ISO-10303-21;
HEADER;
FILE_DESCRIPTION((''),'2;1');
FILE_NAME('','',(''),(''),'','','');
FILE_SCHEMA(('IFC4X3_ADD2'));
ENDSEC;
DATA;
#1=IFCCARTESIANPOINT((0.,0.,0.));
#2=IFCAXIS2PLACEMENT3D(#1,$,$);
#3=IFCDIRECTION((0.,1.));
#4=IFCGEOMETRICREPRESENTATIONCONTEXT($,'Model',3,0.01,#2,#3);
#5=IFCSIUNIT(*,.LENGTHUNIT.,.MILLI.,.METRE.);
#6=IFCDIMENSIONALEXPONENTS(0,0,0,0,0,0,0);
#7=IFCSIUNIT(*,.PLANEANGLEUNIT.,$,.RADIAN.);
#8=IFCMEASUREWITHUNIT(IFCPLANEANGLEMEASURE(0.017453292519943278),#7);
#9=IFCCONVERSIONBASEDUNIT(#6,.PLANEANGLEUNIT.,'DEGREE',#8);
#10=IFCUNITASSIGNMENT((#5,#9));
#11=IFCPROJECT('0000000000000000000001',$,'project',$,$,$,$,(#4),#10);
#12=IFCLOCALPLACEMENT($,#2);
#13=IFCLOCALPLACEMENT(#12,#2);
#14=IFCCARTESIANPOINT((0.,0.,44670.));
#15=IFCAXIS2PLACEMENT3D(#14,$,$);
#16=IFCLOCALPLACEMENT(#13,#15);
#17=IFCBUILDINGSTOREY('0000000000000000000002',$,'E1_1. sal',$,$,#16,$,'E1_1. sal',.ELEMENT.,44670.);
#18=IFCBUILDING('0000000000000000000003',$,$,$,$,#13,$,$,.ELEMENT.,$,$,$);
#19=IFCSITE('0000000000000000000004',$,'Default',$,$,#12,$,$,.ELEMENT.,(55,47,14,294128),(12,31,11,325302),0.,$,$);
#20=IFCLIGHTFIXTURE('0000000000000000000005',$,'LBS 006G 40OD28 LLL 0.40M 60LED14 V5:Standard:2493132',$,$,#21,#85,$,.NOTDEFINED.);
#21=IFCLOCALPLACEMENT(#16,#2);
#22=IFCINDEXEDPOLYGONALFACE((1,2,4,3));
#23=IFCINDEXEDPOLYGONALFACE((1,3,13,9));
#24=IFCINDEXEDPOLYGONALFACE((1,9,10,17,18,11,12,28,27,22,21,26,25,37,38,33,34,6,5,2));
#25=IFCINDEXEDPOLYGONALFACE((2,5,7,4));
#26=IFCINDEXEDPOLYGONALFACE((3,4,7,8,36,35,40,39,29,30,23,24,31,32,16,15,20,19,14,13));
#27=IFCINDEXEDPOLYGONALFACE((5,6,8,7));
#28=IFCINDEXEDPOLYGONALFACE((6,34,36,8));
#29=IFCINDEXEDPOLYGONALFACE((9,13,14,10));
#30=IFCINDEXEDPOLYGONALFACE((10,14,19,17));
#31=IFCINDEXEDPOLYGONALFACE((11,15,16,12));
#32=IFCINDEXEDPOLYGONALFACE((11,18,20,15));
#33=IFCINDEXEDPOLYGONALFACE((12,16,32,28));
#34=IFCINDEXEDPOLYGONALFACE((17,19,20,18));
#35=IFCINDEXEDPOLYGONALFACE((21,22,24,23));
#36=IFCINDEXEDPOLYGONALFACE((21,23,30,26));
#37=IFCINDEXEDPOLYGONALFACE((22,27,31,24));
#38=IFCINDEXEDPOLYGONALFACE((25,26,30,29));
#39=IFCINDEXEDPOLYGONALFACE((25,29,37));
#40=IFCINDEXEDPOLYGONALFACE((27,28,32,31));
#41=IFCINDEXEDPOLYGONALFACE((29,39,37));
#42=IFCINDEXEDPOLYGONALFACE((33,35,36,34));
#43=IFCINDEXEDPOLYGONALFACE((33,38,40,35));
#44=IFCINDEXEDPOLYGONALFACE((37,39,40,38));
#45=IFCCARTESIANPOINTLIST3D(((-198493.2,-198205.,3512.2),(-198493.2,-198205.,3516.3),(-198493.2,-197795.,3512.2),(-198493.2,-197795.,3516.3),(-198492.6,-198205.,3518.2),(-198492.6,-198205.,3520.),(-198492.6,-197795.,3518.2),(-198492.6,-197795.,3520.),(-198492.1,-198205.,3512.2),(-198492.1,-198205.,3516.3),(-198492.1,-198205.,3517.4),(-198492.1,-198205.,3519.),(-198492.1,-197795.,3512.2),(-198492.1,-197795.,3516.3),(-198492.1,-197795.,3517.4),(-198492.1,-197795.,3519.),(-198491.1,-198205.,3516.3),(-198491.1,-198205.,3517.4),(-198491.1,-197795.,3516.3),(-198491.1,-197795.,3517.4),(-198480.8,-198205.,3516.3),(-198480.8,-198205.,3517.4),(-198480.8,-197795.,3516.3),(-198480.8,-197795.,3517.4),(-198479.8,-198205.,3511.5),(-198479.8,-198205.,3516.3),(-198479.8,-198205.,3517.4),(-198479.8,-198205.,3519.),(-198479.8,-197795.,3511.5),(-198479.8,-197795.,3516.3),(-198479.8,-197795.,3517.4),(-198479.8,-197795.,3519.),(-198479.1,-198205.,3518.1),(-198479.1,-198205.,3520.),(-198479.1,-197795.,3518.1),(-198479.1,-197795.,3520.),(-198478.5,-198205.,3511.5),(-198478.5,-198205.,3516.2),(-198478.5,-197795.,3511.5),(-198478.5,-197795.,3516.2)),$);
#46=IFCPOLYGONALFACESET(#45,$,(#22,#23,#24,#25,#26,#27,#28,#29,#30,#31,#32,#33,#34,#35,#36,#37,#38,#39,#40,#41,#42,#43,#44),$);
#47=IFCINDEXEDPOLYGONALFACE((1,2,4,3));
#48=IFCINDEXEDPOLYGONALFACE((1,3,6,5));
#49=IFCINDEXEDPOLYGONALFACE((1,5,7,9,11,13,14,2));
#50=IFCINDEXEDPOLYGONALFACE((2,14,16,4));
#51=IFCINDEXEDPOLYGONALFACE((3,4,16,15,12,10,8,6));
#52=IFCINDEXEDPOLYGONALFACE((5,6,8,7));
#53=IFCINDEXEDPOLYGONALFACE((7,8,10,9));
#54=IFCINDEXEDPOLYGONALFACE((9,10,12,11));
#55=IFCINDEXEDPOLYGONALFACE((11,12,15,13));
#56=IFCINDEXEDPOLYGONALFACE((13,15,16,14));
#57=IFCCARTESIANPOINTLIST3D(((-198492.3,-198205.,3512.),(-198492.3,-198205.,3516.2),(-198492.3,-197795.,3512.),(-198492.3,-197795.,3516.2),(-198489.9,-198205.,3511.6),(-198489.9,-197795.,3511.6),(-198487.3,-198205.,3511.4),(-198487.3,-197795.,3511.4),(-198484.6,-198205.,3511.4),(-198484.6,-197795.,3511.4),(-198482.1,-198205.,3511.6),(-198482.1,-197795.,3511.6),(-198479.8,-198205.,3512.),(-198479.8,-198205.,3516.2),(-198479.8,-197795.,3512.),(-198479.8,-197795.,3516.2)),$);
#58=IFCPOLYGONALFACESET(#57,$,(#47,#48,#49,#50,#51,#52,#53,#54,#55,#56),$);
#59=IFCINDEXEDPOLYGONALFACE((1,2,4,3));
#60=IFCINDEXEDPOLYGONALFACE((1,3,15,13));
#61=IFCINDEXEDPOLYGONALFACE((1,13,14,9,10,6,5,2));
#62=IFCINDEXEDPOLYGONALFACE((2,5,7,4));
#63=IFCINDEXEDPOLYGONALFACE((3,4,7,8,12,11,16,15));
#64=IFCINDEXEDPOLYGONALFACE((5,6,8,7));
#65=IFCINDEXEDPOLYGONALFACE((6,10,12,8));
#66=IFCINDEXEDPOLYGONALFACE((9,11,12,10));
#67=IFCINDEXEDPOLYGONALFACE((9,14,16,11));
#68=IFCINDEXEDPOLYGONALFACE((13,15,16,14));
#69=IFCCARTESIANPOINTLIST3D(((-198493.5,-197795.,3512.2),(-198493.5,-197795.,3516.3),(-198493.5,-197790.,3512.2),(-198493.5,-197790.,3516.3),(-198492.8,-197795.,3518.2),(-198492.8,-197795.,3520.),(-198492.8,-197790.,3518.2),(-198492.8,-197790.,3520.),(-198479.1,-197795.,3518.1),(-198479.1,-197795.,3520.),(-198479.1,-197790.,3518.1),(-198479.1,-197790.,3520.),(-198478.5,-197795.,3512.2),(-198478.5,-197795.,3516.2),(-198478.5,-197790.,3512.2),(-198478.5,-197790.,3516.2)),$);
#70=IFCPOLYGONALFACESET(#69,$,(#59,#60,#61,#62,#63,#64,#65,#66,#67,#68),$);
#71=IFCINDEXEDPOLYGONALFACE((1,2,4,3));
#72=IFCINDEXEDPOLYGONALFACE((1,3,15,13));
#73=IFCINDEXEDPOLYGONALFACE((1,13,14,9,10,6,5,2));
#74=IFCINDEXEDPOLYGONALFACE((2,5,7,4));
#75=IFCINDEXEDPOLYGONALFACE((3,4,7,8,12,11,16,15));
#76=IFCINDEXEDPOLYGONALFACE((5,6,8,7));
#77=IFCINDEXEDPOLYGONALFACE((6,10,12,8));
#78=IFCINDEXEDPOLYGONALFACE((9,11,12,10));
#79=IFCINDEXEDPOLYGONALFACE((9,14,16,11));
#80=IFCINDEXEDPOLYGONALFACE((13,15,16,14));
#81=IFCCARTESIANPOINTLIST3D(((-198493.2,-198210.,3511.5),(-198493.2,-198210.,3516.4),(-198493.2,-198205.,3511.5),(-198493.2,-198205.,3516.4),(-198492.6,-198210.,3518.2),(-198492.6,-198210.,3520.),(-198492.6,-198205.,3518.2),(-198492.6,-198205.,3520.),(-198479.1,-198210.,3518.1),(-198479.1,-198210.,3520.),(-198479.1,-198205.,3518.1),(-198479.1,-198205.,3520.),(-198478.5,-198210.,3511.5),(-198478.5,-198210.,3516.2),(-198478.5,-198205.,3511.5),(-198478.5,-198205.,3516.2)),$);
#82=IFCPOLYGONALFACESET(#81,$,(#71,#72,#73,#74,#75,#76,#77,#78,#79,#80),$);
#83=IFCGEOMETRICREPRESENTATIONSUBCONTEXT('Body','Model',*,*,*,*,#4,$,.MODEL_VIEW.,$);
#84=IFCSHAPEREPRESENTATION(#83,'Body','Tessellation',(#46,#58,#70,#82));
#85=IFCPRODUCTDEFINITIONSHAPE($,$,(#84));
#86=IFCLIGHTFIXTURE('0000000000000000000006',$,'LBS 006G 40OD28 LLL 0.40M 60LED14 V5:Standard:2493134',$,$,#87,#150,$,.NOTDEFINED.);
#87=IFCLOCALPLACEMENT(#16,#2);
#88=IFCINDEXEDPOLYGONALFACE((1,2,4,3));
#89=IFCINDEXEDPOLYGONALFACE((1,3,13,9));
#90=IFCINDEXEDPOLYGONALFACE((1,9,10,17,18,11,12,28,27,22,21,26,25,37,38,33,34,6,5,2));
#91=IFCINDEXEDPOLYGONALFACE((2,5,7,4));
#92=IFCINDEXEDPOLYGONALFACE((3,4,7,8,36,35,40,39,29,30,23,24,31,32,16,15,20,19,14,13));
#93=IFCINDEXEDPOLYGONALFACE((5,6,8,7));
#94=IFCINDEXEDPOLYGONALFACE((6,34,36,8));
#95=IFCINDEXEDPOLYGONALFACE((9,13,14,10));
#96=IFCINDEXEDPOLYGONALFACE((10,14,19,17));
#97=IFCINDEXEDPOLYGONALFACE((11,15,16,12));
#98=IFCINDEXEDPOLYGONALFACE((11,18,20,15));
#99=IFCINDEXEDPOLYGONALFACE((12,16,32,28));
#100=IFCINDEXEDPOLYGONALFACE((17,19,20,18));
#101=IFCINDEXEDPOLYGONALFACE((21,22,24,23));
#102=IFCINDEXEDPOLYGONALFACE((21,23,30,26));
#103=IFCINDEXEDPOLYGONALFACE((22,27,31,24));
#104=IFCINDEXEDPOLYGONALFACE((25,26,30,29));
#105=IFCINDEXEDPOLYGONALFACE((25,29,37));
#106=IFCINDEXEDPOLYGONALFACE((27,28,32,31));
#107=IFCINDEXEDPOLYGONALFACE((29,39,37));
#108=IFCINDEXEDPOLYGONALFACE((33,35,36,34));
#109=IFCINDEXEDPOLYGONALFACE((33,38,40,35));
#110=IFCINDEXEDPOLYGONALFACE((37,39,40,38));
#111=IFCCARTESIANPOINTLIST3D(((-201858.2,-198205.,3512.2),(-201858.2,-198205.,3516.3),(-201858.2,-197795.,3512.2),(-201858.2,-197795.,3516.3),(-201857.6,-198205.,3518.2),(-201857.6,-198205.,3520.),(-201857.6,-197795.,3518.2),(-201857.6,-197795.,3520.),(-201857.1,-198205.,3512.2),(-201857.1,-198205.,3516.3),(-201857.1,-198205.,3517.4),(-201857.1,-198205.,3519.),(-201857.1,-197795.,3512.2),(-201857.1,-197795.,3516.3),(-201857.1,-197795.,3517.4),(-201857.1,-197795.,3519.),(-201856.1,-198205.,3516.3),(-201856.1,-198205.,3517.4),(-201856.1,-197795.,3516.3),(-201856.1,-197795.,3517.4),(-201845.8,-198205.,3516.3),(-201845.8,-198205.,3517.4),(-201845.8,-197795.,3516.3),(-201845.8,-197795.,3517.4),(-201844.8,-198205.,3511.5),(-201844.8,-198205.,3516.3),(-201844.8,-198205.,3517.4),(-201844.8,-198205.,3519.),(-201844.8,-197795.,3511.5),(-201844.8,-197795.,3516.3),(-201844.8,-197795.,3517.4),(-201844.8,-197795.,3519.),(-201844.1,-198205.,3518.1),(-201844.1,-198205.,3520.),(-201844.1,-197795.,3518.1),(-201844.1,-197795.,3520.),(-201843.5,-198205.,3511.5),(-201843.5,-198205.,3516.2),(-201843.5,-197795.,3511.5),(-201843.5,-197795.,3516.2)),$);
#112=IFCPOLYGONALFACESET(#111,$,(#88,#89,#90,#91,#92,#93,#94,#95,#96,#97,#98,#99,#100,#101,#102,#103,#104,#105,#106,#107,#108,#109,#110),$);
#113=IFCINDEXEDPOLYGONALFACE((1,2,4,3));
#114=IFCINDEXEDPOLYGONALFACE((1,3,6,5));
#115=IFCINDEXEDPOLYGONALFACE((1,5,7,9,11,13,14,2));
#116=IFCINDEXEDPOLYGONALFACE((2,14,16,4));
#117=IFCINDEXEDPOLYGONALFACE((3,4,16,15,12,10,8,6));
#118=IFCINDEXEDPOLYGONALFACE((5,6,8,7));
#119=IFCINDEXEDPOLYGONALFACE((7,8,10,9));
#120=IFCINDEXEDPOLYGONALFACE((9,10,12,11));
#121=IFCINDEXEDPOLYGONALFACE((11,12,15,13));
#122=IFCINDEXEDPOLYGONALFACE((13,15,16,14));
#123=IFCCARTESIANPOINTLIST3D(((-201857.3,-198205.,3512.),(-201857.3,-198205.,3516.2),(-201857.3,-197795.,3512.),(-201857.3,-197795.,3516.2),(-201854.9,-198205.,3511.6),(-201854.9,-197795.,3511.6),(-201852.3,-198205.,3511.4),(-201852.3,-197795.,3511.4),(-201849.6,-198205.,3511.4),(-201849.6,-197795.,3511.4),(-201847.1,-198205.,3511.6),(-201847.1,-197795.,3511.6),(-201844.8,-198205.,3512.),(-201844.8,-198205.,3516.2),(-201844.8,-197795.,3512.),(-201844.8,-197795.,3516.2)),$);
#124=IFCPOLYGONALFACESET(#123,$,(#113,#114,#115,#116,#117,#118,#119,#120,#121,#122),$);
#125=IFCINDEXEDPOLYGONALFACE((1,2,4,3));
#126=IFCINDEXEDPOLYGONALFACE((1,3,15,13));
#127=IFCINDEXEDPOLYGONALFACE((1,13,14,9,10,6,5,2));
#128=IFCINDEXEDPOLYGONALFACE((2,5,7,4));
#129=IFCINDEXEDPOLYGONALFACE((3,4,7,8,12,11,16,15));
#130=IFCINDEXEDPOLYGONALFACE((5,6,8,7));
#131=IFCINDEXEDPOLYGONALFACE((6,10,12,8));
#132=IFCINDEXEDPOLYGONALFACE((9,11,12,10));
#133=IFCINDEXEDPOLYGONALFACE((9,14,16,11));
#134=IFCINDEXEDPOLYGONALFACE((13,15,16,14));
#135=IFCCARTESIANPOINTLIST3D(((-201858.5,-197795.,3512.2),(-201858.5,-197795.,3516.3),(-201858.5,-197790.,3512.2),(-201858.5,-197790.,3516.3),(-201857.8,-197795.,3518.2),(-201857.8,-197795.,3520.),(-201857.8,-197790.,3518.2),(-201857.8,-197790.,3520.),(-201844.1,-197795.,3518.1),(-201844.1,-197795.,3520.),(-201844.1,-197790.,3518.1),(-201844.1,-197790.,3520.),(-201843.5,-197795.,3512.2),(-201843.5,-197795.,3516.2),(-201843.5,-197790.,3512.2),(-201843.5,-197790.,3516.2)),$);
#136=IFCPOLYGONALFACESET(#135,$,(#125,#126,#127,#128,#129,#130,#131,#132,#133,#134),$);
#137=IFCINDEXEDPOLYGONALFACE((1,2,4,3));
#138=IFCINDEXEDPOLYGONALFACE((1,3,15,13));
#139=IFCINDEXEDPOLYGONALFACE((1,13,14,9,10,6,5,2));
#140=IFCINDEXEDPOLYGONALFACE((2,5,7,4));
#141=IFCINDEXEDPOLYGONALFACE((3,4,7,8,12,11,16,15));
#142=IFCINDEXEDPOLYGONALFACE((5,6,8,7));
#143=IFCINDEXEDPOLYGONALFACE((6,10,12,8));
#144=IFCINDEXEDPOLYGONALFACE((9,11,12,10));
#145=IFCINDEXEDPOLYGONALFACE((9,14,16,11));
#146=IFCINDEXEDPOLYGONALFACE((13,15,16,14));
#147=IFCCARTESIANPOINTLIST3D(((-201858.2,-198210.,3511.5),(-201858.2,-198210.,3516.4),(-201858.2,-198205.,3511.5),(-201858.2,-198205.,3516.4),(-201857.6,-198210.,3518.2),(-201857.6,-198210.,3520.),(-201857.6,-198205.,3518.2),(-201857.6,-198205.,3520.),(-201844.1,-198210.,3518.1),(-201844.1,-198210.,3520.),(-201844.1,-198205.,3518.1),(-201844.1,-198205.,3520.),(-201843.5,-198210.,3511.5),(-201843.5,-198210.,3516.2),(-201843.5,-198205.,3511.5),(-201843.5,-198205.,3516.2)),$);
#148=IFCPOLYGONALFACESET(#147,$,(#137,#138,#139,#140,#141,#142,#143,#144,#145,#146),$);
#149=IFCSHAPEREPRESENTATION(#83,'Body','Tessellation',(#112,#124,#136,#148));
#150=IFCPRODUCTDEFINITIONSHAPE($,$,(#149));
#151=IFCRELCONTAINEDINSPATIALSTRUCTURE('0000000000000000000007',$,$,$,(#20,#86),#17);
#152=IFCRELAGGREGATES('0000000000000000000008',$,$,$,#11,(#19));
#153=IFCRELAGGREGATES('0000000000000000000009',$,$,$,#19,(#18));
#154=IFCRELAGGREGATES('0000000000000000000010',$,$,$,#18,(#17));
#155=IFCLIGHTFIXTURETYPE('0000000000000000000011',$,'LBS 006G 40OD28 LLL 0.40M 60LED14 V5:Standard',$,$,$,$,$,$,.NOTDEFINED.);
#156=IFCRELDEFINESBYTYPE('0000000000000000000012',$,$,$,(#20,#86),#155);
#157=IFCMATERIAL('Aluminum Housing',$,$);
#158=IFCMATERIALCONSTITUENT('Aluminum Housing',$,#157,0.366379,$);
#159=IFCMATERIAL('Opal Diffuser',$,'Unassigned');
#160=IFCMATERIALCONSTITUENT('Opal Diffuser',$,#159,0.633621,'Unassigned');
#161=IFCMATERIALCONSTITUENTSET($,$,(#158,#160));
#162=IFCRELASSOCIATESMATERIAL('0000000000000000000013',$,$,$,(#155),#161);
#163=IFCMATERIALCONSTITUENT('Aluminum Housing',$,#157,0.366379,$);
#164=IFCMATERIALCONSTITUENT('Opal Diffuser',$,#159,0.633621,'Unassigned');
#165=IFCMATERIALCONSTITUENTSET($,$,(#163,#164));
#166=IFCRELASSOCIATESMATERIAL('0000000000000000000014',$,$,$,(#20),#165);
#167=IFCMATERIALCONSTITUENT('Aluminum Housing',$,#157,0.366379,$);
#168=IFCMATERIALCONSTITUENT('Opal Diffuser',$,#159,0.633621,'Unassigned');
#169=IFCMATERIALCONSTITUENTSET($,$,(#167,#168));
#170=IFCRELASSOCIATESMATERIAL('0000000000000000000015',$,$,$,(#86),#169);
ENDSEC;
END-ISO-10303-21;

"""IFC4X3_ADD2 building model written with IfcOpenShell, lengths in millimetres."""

from ifc_helpers import new_model, entity, si_unit, converted_unit, direction, frame, origin, place, context, subcontext, project, spatial, polyline, outline, extrude, source, transform, mapped, material, constituent, constituent_set, type_object, type_shapes, element, save


model = new_model("IFC4X3_ADD2")

# Units and contexts
model_context = context("Model", 3, precision=0.01, world=origin(), true_north=direction((0.0, 1.0)))
body_context = subcontext(model_context, "Body", "Model", "MODEL_VIEW")
ifc_project = project(units=[si_unit("LENGTHUNIT", "METRE", prefix="MILLI"), converted_unit("PLANEANGLEUNIT", "DEGREE", entity("IfcPlaneAngleMeasure", 0.017453292519943278), si_unit("PLANEANGLEUNIT", "RADIAN"), dimensions=[0, 0, 0, 0, 0, 0, 0])], contexts=[model_context])

# Site, building, storey
site_placement = place(None, origin())
site = spatial("IfcSite", under=ifc_project, at=site_placement, Name="Default", CompositionType="ELEMENT", RefLatitude=(55, 47, 14, 294128), RefLongitude=(12, 31, 11, 325302), RefElevation=0.0)
building_placement = place(site_placement, origin())
building = spatial("IfcBuilding", under=site, at=building_placement, CompositionType="ELEMENT")
storey_placement = place(building_placement, frame((0.0, 0.0, 44670.0)))
storey = spatial("IfcBuildingStorey", under=building, at=storey_placement, Name="E1_1. sal", LongName="E1_1. sal", CompositionType="ELEMENT", Elevation=44670.0)

# Light fixtures
ifc_material_1 = material(Name="Aluminum Housing")
ifc_constituent_1 = constituent(ifc_material_1, Name="Aluminum Housing", fraction=0.366379)
ifc_material_2 = material(Name="Opal Diffuser", Category="Unassigned")
ifc_constituent_2 = constituent(ifc_material_2, Name="Opal Diffuser", Category="Unassigned", fraction=0.633621)
ifc_constituent_set_1 = constituent_set(constituents=[ifc_constituent_1, ifc_constituent_2])
ifc_constituent_3 = constituent(ifc_material_1, Name="Aluminum Housing", fraction=0.366379)
ifc_constituent_4 = constituent(ifc_material_2, Name="Opal Diffuser", Category="Unassigned", fraction=0.633621)
ifc_constituent_set_2 = constituent_set(constituents=[ifc_constituent_3, ifc_constituent_4])
light_fixture_type = type_object("IfcLightFixtureType", Name="LBS 006G 40OD28 LLL 0.40M 60LED14 V5:Standard", PredefinedType="NOTDEFINED", material=ifc_constituent_set_2)
shared_shape_1 = source(origin(), body_context, "Body", "SweptSolid", [
    extrude(outline(polyline([(-5.0, -6.1), (-5.0, -7.4), (-0.3, -7.4), (1.7, -6.8), (3.5, -6.8), (3.5, 6.7), (1.8, 6.7), (-0.1, 7.3), (-4.2, 7.3), (-4.2, 6.2), (-0.1, 6.2), (-0.1, 5.2), (0.9, 5.2), (0.9, 6.2), (2.5, 6.2), (2.5, -6.1), (0.9, -6.1), (0.9, -5.1), (-0.1, -5.1), (-0.1, -6.1), (-5.0, -6.1)])), frame((-205.0, 0.1, 3.5), z_axis=(-1.0, 0.0, 0.0), x_axis=(0.0, 0.0, -1.0)), (0.0, 0.0, -1.0), 410.0),
    extrude(outline(polyline([(-0.8, -6.2), (3.4, -6.2), (3.4, 6.2), (-0.8, 6.2), (-1.2, 3.9), (-1.4, 1.4), (-1.4, -1.3), (-1.2, -3.9), (-0.8, -6.2)])), frame((-205.0, 0.0, 7.2), z_axis=(1.0, 0.0, 0.0), x_axis=(0.0, 0.0, -1.0)), (0.0, 0.0, 1.0), 410.0),
    extrude(outline(polyline([(-4.4, -7.5), (-0.3, -7.5), (1.5, -6.8), (3.3, -6.8), (3.3, 6.9), (1.5, 6.9), (-0.5, 7.4), (-4.4, 7.4), (-4.4, -7.5)])), frame((205.0, 0.0, 3.3), z_axis=(1.0, 0.0, 0.0), x_axis=(0.0, 0.0, -1.0)), (0.0, 0.0, 1.0), 5.0),
    extrude(outline(polyline([(-5.0, -7.4), (-0.1, -7.4), (1.7, -6.7), (3.5, -6.7), (3.5, 6.8), (1.6, 6.8), (-0.3, 7.3), (-5.0, 7.3), (-5.0, -7.4)])), frame((-210.0, 0.2, 3.5), z_axis=(1.0, 0.0, 0.0), x_axis=(0.0, 0.0, -1.0)), (0.0, 0.0, 1.0), 5.0),
])
type_shapes(light_fixture_type, [shared_shape_1])
light_fixture_1_placement = place(storey_placement, frame((-198486.0, -198000.0, 3520.0), z_axis=(0.0, 0.0, -1.0), x_axis=(0.0, 1.0, 0.0)))
element("IfcLightFixture", 1, at=light_fixture_1_placement, inside=storey, type_object=light_fixture_type, material=ifc_constituent_set_1, Name="LBS 006G 40OD28 LLL 0.40M 60LED14 V5:Standard:2493132", PredefinedType="NOTDEFINED", context=body_context, shape_type="MappedRepresentation", body=[
    mapped(shared_shape_1, transform((0.0, 0.0, 0.0), scale=1.0)),
])
ifc_constituent_5 = constituent(ifc_material_1, Name="Aluminum Housing", fraction=0.366379)
ifc_constituent_6 = constituent(ifc_material_2, Name="Opal Diffuser", Category="Unassigned", fraction=0.633621)
ifc_constituent_set_3 = constituent_set(constituents=[ifc_constituent_5, ifc_constituent_6])
light_fixture_2_placement = place(storey_placement, frame((-201851.0, -198000.0, 3520.0), z_axis=(0.0, 0.0, -1.0), x_axis=(0.0, 1.0, 0.0)))
element("IfcLightFixture", 2, at=light_fixture_2_placement, inside=storey, type_object=light_fixture_type, material=ifc_constituent_set_3, Name="LBS 006G 40OD28 LLL 0.40M 60LED14 V5:Standard:2493134", PredefinedType="NOTDEFINED", context=body_context, shape_type="MappedRepresentation", body=[
    mapped(shared_shape_1, transform((0.0, 0.0, 0.0), scale=1.0)),
])

save(model, "model.ifc")
